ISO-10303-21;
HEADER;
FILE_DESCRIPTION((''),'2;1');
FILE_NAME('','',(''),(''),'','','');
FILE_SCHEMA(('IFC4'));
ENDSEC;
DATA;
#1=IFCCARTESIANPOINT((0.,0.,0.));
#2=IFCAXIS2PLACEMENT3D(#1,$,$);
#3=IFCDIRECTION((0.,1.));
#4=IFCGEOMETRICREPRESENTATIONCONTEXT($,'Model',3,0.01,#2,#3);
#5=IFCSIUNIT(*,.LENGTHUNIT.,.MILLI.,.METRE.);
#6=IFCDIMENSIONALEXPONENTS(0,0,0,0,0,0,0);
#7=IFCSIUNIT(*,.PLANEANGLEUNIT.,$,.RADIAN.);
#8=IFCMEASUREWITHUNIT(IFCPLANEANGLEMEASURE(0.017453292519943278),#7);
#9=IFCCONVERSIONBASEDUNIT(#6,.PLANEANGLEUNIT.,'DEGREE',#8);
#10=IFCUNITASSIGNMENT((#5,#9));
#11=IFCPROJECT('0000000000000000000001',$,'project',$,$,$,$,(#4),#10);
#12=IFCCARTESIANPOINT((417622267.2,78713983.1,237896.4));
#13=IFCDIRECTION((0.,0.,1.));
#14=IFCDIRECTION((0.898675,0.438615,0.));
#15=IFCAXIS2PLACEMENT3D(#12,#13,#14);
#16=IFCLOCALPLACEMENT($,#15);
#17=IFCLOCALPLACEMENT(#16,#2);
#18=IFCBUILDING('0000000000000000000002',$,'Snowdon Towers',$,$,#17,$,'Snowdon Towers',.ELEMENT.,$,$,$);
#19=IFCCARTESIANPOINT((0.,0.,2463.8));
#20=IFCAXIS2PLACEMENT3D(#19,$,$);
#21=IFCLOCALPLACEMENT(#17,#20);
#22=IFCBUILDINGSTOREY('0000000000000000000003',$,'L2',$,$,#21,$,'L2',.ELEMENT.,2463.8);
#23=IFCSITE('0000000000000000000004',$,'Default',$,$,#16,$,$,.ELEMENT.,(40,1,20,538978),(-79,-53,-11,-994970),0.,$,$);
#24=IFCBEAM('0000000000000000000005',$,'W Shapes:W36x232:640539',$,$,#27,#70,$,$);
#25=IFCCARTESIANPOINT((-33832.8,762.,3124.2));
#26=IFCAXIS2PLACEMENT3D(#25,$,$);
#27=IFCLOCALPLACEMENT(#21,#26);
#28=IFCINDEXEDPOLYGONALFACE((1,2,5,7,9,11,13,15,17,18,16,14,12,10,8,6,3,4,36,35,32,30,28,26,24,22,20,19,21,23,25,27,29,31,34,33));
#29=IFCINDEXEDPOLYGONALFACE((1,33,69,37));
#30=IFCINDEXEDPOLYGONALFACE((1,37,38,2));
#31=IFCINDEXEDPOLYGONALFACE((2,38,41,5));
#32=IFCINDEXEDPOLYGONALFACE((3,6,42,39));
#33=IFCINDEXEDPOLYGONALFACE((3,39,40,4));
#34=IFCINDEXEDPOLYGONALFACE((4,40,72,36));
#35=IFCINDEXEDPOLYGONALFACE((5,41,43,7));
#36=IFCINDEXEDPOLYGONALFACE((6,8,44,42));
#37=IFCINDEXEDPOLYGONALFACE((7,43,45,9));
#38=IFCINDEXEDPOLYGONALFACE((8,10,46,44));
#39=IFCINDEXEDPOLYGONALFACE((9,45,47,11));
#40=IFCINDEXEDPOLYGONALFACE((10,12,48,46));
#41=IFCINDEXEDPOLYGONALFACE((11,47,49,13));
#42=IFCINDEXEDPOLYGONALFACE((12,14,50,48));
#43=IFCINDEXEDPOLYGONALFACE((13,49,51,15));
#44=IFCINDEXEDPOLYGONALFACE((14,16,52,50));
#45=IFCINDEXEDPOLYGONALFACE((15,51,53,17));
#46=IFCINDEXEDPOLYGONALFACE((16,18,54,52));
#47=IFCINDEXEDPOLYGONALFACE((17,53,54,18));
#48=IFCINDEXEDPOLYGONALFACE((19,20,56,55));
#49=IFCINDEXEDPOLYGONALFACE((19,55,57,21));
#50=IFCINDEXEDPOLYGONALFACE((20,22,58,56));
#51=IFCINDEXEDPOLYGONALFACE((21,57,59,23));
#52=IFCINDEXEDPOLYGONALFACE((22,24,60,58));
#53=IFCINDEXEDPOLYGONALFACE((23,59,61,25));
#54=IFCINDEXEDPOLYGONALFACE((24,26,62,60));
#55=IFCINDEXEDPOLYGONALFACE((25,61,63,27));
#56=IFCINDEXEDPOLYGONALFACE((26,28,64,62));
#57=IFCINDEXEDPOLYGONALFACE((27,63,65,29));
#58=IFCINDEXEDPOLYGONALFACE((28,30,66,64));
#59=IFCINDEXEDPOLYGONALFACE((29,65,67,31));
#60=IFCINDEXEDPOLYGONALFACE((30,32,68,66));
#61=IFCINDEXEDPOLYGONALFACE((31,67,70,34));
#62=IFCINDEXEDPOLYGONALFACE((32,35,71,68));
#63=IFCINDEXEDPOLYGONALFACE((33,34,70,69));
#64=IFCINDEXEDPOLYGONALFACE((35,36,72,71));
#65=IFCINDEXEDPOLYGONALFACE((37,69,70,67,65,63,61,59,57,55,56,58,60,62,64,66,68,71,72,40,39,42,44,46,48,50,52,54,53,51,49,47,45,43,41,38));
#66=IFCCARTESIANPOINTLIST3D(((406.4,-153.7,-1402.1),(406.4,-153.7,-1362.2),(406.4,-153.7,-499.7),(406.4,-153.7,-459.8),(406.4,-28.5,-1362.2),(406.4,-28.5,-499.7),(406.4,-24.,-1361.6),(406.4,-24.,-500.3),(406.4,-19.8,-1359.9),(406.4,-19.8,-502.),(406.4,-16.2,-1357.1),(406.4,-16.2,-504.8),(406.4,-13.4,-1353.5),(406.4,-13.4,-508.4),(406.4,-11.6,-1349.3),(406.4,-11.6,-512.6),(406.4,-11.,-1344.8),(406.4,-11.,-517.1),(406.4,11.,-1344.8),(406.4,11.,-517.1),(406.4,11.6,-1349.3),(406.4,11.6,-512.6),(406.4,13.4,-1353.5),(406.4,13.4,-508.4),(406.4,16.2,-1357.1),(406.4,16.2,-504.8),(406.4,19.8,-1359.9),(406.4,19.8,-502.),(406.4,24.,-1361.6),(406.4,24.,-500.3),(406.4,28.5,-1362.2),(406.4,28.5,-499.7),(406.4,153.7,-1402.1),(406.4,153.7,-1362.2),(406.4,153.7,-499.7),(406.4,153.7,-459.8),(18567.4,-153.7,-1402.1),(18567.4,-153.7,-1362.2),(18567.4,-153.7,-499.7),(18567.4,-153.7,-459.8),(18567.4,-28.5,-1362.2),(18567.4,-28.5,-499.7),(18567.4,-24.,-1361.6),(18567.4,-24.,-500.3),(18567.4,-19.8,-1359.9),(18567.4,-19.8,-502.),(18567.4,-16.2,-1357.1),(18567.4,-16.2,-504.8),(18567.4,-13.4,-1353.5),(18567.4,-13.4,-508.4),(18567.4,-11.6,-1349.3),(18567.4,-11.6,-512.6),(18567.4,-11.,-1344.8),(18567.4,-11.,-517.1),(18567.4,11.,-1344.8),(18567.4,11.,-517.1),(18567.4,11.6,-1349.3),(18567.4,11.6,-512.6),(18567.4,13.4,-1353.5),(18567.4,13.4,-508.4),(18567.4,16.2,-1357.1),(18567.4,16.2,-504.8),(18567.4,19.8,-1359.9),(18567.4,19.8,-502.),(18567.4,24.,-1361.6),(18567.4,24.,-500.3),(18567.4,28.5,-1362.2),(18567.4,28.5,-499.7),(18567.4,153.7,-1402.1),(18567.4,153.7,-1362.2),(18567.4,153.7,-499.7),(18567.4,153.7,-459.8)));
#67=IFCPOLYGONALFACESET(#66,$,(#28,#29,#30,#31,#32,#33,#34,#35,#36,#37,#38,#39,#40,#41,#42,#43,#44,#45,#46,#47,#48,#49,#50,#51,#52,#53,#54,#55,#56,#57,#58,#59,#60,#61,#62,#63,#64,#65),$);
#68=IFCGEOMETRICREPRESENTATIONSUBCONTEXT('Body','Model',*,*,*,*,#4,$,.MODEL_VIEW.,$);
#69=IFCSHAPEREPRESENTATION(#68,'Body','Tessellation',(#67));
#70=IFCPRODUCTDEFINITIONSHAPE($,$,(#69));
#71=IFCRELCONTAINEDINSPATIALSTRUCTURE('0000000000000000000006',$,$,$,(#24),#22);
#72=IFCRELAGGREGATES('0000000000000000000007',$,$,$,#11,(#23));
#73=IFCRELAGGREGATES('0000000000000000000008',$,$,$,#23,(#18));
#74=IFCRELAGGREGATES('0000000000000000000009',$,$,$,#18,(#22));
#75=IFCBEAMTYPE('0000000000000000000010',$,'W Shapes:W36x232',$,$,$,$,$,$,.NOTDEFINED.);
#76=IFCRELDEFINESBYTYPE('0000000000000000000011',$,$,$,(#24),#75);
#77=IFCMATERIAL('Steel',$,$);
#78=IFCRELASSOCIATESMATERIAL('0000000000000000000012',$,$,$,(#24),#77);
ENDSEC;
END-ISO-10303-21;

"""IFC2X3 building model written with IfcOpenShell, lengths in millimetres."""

from ifc_helpers import new_model, entity, si_unit, converted_unit, direction, frame, frame_2d, origin, place, context, subcontext, project, spatial, i_section, extrude, material, type_object, element, save


model = new_model("IFC2X3")

# Units and contexts
model_context = context("Model", 3, precision=0.01, world=origin(), true_north=direction((0.0, 1.0)))
body_context = subcontext(model_context, "Body", "Model", "MODEL_VIEW")
ifc_project = project(units=[si_unit("LENGTHUNIT", "METRE", prefix="MILLI"), converted_unit("PLANEANGLEUNIT", "DEGREE", entity("IfcPlaneAngleMeasure", 0.017453292519943278), si_unit("PLANEANGLEUNIT", "RADIAN"), dimensions=[0, 0, 0, 0, 0, 0, 0])], contexts=[model_context])

# Site, building, storey
site_placement = place(None, frame((417622267.2, 78713983.1, 237896.4), z_axis=(0.0, 0.0, 1.0), x_axis=(0.898675, 0.438615, 0.0)))
site = spatial("IfcSite", under=ifc_project, at=site_placement, Name="Default", CompositionType="ELEMENT", RefLatitude=(40, 1, 20, 538978), RefLongitude=(-79, -53, -11, -994970), RefElevation=0.0)
building_placement = place(site_placement, origin())
building = spatial("IfcBuilding", under=site, at=building_placement, Name="Snowdon Towers", LongName="Snowdon Towers", CompositionType="ELEMENT")
storey_placement = place(building_placement, frame((0.0, 0.0, 2463.8)))
storey = spatial("IfcBuildingStorey", under=building, at=storey_placement, Name="L2", LongName="L2", CompositionType="ELEMENT", Elevation=2463.8)

# Beam
ifc_material = material(Name="Steel")
beam_type_1 = type_object("IfcBeamType", Name="W Shapes:W36x232", PredefinedType="NOTDEFINED")
beam_1_placement = place(storey_placement, frame((-33832.8, 762.0, 3124.2)))
element("IfcBeam", 1, at=beam_1_placement, inside=storey, type_object=beam_type_1, material=ifc_material, Name="W Shapes:W36x232:640539", context=body_context, shape_type="SweptSolid", body=[
    extrude(i_section(OverallWidth=307.3, OverallDepth=942.3, WebThickness=22.1, FlangeThickness=39.9, FilletRadius=17.5, at=frame_2d((0.0, 0.0), x_axis=(0.0, 1.0))), frame((406.4, 0.0, -930.9), z_axis=(1.0, 0.0, 0.0), x_axis=(0.0, 0.0, -1.0)), (0.0, 0.0, 1.0), 18161.0),
])

save(model, "model.ifc")
